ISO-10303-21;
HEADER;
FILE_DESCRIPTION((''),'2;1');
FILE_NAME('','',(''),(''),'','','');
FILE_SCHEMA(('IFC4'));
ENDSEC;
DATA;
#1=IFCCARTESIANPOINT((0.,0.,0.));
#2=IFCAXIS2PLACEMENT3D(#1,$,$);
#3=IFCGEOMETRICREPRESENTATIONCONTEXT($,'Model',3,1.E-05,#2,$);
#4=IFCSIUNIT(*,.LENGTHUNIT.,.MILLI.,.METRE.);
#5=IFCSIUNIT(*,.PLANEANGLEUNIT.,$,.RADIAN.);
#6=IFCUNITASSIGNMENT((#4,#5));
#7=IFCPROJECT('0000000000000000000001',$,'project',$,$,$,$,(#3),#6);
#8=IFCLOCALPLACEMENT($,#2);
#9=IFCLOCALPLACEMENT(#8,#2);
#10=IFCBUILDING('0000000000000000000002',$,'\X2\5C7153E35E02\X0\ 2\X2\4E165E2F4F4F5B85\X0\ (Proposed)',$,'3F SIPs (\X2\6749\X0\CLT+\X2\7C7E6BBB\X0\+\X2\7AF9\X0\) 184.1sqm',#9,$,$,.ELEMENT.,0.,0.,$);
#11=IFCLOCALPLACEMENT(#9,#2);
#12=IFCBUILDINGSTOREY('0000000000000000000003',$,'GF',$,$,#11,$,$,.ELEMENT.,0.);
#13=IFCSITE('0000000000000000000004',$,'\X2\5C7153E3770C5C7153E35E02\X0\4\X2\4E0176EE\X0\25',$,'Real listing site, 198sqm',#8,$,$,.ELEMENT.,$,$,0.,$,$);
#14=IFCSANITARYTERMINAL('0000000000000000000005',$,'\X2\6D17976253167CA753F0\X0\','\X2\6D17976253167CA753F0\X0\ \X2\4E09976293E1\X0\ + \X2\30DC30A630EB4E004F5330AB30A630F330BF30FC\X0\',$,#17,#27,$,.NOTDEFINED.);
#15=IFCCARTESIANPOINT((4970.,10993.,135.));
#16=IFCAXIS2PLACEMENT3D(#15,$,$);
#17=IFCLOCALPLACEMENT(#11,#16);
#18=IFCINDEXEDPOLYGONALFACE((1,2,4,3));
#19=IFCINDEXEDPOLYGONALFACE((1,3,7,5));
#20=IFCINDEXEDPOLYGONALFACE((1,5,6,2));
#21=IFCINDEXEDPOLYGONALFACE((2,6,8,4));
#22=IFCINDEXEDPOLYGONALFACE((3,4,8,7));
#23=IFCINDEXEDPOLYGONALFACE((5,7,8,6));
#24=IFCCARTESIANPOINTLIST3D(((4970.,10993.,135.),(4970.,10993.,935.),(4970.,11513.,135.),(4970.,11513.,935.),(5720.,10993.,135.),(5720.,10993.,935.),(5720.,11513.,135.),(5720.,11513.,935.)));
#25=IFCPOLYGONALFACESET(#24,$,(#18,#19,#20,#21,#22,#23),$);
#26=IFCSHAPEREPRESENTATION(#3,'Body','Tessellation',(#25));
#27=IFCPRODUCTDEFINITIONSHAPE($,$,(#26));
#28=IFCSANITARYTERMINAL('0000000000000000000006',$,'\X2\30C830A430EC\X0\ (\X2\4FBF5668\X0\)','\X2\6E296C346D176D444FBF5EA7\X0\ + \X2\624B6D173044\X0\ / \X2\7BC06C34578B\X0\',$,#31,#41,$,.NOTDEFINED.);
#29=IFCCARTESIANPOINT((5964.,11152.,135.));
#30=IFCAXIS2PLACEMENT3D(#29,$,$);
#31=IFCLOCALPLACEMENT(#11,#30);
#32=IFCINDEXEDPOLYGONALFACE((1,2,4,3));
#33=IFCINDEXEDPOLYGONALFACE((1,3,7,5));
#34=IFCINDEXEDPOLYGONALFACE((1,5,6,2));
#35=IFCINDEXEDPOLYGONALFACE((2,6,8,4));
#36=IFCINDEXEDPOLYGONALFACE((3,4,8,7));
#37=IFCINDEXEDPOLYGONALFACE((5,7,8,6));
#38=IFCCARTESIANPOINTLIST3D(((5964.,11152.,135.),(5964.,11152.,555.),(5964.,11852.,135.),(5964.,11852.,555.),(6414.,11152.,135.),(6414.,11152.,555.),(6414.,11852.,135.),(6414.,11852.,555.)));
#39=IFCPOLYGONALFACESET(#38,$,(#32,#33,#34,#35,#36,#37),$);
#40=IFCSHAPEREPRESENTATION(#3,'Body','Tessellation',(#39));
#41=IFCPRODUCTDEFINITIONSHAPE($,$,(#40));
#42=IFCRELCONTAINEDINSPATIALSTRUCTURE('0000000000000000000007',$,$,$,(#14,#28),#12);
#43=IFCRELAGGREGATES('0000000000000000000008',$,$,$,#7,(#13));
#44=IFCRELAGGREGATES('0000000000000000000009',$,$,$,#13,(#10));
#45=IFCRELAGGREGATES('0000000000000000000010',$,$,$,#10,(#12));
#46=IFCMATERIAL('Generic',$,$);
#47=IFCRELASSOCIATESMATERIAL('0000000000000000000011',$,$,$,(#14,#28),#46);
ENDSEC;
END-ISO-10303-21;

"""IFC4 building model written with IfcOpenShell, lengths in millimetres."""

from ifc_helpers import new_model, si_unit, frame, frame_2d, origin, place, context, project, spatial, rectangle, extrude, material, element, save


model = new_model("IFC4")

# Units and contexts
model_context = context("Model", 3, precision=1e-05, world=origin())
ifc_project = project(units=[si_unit("LENGTHUNIT", "METRE", prefix="MILLI"), si_unit("PLANEANGLEUNIT", "RADIAN")], contexts=[model_context])

# Site, building, storey
site_placement = place(None, origin())
site = spatial("IfcSite", under=ifc_project, at=site_placement, Name="山口県山口市4丁目25", ObjectType="Real listing site, 198sqm", CompositionType="ELEMENT", RefElevation=0.0)
building_placement = place(site_placement, origin())
building = spatial("IfcBuilding", under=site, at=building_placement, Name="山口市 2世帯住宅 (Proposed)", ObjectType="3F SIPs (杉CLT+籾殻+竹) 184.1sqm", CompositionType="ELEMENT", ElevationOfRefHeight=0.0, ElevationOfTerrain=0.0)
storey_placement = place(building_placement, origin())
storey = spatial("IfcBuildingStorey", under=building, at=storey_placement, Name="GF", CompositionType="ELEMENT", Elevation=0.0)

# Shared definitions
ifc_material_1 = material(Name="Generic")

# Sanitary terminals
sanitary_terminal_1_placement = place(storey_placement, frame((4970.0, 10993.0, 135.0)))
element("IfcSanitaryTerminal", 1, at=sanitary_terminal_1_placement, inside=storey, material=ifc_material_1, Name="洗面化粧台", Description="洗面化粧台 三面鏡 + ボウル一体カウンター", PredefinedType="NOTDEFINED", context=model_context, shape_type="SweptSolid", body=[
    extrude(rectangle(XDim=750.0, YDim=520.0, at=frame_2d((375.0, 260.0))), frame((4970.0, 10993.0, 135.0)), (0.0, 0.0, 1.0), 800.0),
])
sanitary_terminal_2_placement = place(storey_placement, frame((5964.0, 11152.0, 135.0)))
element("IfcSanitaryTerminal", 2, at=sanitary_terminal_2_placement, inside=storey, material=ifc_material_1, Name="トイレ (便器)", Description="温水洗浄便座 + 手洗い / 節水型", PredefinedType="NOTDEFINED", context=model_context, shape_type="SweptSolid", body=[
    extrude(rectangle(XDim=450.0, YDim=700.0, at=frame_2d((225.0, 350.0))), frame((5964.0, 11152.0, 135.0)), (0.0, 0.0, 1.0), 420.0),
])

save(model, "model.ifc")
